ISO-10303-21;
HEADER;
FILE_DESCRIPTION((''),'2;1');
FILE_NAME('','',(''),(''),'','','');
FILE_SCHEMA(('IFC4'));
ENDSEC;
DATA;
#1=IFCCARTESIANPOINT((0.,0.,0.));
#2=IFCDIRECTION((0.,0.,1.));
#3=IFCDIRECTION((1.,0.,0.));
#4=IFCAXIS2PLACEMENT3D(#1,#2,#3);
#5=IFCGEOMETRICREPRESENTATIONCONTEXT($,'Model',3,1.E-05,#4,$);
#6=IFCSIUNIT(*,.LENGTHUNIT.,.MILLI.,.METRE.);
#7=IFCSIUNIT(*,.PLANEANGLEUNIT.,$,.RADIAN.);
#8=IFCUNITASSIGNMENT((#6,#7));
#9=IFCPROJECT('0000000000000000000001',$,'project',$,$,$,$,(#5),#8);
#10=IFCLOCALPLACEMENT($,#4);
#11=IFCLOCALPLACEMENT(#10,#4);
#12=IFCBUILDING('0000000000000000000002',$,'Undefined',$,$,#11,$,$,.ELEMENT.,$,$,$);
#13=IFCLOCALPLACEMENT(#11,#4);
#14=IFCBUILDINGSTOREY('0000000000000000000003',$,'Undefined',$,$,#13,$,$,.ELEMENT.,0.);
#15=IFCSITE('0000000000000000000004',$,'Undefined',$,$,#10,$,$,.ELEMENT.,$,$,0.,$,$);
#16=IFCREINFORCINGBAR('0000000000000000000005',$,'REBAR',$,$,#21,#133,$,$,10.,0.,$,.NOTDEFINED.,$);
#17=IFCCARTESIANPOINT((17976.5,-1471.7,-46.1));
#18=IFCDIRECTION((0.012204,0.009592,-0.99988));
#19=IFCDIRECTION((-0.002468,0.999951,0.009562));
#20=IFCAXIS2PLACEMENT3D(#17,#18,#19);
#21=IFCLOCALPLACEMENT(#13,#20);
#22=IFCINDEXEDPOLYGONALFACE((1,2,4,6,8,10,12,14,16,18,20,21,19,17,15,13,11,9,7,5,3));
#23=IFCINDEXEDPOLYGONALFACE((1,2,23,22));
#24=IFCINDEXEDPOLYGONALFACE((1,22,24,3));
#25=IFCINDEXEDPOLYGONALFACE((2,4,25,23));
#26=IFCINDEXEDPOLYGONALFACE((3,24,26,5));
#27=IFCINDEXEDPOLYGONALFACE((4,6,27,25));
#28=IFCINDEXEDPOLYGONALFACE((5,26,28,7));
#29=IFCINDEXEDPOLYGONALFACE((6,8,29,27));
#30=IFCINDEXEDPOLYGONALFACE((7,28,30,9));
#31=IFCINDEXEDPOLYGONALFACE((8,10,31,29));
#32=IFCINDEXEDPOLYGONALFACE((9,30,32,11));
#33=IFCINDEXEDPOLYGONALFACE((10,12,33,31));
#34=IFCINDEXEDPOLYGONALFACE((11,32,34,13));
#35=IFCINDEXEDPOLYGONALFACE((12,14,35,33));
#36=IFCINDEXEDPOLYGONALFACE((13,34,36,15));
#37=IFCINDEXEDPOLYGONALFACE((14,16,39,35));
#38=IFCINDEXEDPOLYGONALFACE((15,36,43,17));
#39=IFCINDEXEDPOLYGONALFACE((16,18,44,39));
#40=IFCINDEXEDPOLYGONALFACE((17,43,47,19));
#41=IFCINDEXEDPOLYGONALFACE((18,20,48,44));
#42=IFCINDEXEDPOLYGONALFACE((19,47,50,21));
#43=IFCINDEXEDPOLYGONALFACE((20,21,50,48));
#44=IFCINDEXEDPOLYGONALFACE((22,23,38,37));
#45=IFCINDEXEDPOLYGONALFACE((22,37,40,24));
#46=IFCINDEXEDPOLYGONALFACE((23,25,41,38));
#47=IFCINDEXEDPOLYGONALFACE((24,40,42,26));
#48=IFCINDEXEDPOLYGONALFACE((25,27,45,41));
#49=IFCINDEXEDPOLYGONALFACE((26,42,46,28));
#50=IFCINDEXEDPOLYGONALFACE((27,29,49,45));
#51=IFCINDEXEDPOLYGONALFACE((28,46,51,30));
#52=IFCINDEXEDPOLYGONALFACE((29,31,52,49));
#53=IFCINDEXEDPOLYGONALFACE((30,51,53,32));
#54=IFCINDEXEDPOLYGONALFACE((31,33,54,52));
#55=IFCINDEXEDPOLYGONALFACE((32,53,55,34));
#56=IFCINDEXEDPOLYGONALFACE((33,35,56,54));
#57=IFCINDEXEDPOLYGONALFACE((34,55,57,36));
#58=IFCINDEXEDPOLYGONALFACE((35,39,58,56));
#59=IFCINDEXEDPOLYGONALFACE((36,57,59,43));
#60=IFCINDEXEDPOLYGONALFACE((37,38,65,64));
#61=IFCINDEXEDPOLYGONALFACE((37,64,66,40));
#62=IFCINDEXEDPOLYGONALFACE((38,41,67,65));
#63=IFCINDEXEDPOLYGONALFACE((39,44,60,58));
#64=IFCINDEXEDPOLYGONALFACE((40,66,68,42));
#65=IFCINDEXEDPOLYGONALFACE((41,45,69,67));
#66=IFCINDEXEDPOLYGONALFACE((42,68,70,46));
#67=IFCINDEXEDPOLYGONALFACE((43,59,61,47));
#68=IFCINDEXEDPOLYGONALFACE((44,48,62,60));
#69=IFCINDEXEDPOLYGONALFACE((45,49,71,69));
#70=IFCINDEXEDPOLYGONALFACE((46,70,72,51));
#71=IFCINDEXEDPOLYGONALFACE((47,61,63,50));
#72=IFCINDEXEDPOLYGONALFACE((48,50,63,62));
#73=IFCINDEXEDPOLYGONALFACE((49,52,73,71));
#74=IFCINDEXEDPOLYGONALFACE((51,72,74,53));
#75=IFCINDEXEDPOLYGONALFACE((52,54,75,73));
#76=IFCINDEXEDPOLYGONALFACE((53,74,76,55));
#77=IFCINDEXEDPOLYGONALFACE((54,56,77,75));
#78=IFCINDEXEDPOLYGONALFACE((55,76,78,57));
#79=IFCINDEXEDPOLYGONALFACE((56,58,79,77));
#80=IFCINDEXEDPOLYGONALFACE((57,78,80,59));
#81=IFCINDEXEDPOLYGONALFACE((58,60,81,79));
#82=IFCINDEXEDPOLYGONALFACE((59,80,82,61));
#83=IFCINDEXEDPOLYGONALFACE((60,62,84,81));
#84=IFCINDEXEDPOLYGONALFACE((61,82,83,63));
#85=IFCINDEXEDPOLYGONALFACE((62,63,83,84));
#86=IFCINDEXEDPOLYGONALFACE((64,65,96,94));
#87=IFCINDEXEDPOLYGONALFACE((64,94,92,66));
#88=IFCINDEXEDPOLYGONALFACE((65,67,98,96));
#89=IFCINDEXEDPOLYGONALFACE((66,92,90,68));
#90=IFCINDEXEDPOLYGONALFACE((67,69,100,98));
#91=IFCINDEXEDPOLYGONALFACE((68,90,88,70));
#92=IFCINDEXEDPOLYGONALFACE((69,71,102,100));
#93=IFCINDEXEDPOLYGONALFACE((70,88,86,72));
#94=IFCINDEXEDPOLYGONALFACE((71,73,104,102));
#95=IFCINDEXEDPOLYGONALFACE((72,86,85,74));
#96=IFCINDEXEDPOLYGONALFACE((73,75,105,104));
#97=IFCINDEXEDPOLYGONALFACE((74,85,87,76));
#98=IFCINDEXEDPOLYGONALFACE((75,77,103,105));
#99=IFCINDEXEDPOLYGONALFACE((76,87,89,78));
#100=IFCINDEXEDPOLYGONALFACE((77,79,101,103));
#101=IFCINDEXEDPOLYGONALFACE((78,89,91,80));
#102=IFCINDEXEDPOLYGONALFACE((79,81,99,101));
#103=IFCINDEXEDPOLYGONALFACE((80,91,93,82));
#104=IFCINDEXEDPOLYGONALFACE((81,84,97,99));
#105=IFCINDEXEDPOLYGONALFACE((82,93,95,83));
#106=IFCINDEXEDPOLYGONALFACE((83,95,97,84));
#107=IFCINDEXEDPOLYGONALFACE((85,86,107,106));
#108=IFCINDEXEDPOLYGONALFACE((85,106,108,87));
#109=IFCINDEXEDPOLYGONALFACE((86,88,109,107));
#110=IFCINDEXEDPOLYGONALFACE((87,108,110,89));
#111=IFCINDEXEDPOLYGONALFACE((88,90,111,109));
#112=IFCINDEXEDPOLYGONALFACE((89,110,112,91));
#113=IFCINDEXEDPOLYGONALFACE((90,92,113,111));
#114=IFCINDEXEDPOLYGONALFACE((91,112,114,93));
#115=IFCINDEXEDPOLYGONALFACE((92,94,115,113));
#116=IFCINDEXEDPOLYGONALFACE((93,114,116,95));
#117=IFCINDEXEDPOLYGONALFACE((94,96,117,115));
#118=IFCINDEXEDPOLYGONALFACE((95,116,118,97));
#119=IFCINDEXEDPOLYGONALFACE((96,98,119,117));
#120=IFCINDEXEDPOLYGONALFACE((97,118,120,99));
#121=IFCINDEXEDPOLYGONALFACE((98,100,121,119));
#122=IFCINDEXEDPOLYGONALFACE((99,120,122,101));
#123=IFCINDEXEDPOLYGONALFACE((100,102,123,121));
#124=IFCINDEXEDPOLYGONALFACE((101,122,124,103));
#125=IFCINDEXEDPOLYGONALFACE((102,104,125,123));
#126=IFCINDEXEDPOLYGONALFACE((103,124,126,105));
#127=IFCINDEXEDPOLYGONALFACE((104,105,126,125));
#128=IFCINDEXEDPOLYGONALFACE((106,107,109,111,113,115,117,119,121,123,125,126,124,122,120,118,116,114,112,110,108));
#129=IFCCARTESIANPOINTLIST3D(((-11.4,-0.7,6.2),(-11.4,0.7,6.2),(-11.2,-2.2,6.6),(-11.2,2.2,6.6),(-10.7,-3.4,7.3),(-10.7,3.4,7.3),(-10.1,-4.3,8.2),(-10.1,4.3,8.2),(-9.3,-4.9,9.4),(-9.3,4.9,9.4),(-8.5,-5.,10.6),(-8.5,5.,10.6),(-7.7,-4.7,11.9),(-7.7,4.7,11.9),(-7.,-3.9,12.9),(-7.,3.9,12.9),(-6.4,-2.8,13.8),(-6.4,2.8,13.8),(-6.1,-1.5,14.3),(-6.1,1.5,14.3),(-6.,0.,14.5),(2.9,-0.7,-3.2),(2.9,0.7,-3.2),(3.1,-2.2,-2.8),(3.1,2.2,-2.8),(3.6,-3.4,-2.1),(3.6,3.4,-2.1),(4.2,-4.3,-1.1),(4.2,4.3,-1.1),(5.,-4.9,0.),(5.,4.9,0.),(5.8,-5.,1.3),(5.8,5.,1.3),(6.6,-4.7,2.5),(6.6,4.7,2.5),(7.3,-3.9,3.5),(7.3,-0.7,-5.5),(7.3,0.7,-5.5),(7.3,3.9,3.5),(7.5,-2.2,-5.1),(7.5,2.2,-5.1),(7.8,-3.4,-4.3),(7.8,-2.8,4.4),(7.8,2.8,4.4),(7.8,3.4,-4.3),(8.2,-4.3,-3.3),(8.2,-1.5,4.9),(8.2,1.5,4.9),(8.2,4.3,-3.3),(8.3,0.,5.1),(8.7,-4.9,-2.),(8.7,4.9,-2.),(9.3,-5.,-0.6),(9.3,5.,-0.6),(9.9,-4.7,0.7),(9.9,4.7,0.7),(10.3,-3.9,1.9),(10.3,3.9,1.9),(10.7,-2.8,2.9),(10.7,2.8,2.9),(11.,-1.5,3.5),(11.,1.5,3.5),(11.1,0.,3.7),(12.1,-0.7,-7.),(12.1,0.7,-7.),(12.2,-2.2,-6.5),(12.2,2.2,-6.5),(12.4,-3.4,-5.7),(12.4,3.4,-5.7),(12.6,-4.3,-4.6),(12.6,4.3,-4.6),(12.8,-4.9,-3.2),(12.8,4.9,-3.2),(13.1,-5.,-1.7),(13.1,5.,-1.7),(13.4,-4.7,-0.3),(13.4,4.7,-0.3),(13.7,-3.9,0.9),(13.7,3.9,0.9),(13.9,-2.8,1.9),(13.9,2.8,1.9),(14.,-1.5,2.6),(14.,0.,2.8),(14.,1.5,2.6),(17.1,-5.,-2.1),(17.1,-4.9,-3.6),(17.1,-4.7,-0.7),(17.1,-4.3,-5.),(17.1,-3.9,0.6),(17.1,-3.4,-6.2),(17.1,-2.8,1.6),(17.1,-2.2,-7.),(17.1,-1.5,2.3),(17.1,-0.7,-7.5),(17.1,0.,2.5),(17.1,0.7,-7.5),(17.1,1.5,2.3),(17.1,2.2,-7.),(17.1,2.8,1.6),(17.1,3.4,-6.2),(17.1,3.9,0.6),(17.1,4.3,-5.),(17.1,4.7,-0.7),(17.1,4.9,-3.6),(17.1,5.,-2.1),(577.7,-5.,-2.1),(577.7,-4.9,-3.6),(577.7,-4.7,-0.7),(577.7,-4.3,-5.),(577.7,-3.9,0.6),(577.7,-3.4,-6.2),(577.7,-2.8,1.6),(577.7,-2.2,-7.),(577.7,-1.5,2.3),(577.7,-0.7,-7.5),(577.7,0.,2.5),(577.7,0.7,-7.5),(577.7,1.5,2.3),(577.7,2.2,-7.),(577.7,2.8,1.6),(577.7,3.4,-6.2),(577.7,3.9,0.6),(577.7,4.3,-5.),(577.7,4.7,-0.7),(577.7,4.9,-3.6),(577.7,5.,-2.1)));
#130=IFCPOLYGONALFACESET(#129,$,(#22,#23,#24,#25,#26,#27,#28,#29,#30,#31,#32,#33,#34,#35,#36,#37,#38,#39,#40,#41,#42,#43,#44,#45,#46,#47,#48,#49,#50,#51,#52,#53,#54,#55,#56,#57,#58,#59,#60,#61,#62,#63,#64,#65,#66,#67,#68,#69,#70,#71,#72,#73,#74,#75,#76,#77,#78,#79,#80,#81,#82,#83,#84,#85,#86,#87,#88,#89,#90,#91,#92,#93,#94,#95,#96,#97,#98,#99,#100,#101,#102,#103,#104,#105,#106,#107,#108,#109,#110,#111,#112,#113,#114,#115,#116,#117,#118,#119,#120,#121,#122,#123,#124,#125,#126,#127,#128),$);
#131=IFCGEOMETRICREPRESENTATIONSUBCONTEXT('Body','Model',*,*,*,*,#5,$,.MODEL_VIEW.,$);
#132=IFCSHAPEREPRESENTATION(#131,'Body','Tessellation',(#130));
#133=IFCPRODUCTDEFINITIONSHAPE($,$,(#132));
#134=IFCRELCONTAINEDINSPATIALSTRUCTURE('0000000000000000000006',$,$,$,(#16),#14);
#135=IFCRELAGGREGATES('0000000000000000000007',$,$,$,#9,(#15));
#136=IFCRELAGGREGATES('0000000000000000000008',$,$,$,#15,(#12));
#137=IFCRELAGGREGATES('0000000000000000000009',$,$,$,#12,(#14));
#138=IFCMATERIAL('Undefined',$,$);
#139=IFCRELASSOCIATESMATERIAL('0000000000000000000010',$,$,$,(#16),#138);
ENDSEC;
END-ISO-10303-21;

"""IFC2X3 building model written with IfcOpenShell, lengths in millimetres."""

from ifc_helpers import new_model, entity, si_unit, frame, origin_with_axes, place, context, subcontext, project, spatial, source, transform, mapped, material, element, save


model = new_model("IFC2X3")

# Units and contexts
model_context = context("Model", 3, precision=1e-05, world=origin_with_axes())
body_context = subcontext(model_context, "Body", "Model", "MODEL_VIEW")
ifc_project = project(units=[si_unit("LENGTHUNIT", "METRE", prefix="MILLI"), si_unit("PLANEANGLEUNIT", "RADIAN")], contexts=[model_context])

# Site, building, storey
site_placement = place(None, origin_with_axes())
site = spatial("IfcSite", under=ifc_project, at=site_placement, Name="Undefined", CompositionType="ELEMENT", RefElevation=0.0)
building_placement = place(site_placement, origin_with_axes())
building = spatial("IfcBuilding", under=site, at=building_placement, Name="Undefined", CompositionType="ELEMENT")
storey_placement = place(building_placement, origin_with_axes())
storey = spatial("IfcBuildingStorey", under=building, at=storey_placement, Name="Undefined", CompositionType="ELEMENT", Elevation=0.0)

# Reinforcing bar
ifc_material_1 = material(Name="Undefined")
shared_shape_1 = source(origin_with_axes(), body_context, "Body", "AdvancedSweptSolid", [
    entity("IfcSweptDiskSolid", entity("IfcCompositeCurve", [entity("IfcCompositeCurveSegment", "CONTINUOUS", True, entity("IfcTrimmedCurve", entity("IfcLine", entity("IfcCartesianPoint", [0.0, 0.0, 0.0]), entity("IfcVector", entity("IfcDirection", [0.835483, 0.0, -0.549516]), 1.0)), [entity("IfcParameterValue", 0.0)], [entity("IfcParameterValue", 17.082101)], True, "PARAMETER")), entity("IfcCompositeCurveSegment", "CONTINUOUS", True, entity("IfcTrimmedCurve", entity("IfcCircle", entity("IfcAxis2Placement3D", entity("IfcCartesianPoint", [25.8, 0.0, 8.2]), entity("IfcDirection", [0.0, -1.0, 0.0]), entity("IfcDirection", [-0.549516, 0.0, -0.835483])), 21.0), [entity("IfcParameterValue", 0.0)], [entity("IfcParameterValue", 0.581785)], True, "PARAMETER")), entity("IfcCompositeCurveSegment", "DISCONTINUOUS", True, entity("IfcTrimmedCurve", entity("IfcLine", entity("IfcCartesianPoint", [25.8, 0.0, -12.8]), entity("IfcVector", entity("IfcDirection", [1.0, 0.0, 0.0]), 1.0)), [entity("IfcParameterValue", 0.0)], [entity("IfcParameterValue", 560.593055)], True, "PARAMETER"))], False), 5.0, None, 0.0, 578.3),
])
reinforcing_bar_1_placement = place(storey_placement, frame((17976.5, -1471.7, -46.1), z_axis=(0.012204, 0.009592, -0.99988), x_axis=(-0.002468, 0.999951, 0.009562)))
element("IfcReinforcingBar", 1, at=reinforcing_bar_1_placement, inside=storey, material=ifc_material_1, Name="REBAR", BarRole="NOTDEFINED", CrossSectionArea=0.0, NominalDiameter=10.0, context=body_context, shape_type="MappedRepresentation", body=[
    mapped(shared_shape_1, transform((-8.7, 0.0, 10.3))),
])

save(model, "model.ifc")
